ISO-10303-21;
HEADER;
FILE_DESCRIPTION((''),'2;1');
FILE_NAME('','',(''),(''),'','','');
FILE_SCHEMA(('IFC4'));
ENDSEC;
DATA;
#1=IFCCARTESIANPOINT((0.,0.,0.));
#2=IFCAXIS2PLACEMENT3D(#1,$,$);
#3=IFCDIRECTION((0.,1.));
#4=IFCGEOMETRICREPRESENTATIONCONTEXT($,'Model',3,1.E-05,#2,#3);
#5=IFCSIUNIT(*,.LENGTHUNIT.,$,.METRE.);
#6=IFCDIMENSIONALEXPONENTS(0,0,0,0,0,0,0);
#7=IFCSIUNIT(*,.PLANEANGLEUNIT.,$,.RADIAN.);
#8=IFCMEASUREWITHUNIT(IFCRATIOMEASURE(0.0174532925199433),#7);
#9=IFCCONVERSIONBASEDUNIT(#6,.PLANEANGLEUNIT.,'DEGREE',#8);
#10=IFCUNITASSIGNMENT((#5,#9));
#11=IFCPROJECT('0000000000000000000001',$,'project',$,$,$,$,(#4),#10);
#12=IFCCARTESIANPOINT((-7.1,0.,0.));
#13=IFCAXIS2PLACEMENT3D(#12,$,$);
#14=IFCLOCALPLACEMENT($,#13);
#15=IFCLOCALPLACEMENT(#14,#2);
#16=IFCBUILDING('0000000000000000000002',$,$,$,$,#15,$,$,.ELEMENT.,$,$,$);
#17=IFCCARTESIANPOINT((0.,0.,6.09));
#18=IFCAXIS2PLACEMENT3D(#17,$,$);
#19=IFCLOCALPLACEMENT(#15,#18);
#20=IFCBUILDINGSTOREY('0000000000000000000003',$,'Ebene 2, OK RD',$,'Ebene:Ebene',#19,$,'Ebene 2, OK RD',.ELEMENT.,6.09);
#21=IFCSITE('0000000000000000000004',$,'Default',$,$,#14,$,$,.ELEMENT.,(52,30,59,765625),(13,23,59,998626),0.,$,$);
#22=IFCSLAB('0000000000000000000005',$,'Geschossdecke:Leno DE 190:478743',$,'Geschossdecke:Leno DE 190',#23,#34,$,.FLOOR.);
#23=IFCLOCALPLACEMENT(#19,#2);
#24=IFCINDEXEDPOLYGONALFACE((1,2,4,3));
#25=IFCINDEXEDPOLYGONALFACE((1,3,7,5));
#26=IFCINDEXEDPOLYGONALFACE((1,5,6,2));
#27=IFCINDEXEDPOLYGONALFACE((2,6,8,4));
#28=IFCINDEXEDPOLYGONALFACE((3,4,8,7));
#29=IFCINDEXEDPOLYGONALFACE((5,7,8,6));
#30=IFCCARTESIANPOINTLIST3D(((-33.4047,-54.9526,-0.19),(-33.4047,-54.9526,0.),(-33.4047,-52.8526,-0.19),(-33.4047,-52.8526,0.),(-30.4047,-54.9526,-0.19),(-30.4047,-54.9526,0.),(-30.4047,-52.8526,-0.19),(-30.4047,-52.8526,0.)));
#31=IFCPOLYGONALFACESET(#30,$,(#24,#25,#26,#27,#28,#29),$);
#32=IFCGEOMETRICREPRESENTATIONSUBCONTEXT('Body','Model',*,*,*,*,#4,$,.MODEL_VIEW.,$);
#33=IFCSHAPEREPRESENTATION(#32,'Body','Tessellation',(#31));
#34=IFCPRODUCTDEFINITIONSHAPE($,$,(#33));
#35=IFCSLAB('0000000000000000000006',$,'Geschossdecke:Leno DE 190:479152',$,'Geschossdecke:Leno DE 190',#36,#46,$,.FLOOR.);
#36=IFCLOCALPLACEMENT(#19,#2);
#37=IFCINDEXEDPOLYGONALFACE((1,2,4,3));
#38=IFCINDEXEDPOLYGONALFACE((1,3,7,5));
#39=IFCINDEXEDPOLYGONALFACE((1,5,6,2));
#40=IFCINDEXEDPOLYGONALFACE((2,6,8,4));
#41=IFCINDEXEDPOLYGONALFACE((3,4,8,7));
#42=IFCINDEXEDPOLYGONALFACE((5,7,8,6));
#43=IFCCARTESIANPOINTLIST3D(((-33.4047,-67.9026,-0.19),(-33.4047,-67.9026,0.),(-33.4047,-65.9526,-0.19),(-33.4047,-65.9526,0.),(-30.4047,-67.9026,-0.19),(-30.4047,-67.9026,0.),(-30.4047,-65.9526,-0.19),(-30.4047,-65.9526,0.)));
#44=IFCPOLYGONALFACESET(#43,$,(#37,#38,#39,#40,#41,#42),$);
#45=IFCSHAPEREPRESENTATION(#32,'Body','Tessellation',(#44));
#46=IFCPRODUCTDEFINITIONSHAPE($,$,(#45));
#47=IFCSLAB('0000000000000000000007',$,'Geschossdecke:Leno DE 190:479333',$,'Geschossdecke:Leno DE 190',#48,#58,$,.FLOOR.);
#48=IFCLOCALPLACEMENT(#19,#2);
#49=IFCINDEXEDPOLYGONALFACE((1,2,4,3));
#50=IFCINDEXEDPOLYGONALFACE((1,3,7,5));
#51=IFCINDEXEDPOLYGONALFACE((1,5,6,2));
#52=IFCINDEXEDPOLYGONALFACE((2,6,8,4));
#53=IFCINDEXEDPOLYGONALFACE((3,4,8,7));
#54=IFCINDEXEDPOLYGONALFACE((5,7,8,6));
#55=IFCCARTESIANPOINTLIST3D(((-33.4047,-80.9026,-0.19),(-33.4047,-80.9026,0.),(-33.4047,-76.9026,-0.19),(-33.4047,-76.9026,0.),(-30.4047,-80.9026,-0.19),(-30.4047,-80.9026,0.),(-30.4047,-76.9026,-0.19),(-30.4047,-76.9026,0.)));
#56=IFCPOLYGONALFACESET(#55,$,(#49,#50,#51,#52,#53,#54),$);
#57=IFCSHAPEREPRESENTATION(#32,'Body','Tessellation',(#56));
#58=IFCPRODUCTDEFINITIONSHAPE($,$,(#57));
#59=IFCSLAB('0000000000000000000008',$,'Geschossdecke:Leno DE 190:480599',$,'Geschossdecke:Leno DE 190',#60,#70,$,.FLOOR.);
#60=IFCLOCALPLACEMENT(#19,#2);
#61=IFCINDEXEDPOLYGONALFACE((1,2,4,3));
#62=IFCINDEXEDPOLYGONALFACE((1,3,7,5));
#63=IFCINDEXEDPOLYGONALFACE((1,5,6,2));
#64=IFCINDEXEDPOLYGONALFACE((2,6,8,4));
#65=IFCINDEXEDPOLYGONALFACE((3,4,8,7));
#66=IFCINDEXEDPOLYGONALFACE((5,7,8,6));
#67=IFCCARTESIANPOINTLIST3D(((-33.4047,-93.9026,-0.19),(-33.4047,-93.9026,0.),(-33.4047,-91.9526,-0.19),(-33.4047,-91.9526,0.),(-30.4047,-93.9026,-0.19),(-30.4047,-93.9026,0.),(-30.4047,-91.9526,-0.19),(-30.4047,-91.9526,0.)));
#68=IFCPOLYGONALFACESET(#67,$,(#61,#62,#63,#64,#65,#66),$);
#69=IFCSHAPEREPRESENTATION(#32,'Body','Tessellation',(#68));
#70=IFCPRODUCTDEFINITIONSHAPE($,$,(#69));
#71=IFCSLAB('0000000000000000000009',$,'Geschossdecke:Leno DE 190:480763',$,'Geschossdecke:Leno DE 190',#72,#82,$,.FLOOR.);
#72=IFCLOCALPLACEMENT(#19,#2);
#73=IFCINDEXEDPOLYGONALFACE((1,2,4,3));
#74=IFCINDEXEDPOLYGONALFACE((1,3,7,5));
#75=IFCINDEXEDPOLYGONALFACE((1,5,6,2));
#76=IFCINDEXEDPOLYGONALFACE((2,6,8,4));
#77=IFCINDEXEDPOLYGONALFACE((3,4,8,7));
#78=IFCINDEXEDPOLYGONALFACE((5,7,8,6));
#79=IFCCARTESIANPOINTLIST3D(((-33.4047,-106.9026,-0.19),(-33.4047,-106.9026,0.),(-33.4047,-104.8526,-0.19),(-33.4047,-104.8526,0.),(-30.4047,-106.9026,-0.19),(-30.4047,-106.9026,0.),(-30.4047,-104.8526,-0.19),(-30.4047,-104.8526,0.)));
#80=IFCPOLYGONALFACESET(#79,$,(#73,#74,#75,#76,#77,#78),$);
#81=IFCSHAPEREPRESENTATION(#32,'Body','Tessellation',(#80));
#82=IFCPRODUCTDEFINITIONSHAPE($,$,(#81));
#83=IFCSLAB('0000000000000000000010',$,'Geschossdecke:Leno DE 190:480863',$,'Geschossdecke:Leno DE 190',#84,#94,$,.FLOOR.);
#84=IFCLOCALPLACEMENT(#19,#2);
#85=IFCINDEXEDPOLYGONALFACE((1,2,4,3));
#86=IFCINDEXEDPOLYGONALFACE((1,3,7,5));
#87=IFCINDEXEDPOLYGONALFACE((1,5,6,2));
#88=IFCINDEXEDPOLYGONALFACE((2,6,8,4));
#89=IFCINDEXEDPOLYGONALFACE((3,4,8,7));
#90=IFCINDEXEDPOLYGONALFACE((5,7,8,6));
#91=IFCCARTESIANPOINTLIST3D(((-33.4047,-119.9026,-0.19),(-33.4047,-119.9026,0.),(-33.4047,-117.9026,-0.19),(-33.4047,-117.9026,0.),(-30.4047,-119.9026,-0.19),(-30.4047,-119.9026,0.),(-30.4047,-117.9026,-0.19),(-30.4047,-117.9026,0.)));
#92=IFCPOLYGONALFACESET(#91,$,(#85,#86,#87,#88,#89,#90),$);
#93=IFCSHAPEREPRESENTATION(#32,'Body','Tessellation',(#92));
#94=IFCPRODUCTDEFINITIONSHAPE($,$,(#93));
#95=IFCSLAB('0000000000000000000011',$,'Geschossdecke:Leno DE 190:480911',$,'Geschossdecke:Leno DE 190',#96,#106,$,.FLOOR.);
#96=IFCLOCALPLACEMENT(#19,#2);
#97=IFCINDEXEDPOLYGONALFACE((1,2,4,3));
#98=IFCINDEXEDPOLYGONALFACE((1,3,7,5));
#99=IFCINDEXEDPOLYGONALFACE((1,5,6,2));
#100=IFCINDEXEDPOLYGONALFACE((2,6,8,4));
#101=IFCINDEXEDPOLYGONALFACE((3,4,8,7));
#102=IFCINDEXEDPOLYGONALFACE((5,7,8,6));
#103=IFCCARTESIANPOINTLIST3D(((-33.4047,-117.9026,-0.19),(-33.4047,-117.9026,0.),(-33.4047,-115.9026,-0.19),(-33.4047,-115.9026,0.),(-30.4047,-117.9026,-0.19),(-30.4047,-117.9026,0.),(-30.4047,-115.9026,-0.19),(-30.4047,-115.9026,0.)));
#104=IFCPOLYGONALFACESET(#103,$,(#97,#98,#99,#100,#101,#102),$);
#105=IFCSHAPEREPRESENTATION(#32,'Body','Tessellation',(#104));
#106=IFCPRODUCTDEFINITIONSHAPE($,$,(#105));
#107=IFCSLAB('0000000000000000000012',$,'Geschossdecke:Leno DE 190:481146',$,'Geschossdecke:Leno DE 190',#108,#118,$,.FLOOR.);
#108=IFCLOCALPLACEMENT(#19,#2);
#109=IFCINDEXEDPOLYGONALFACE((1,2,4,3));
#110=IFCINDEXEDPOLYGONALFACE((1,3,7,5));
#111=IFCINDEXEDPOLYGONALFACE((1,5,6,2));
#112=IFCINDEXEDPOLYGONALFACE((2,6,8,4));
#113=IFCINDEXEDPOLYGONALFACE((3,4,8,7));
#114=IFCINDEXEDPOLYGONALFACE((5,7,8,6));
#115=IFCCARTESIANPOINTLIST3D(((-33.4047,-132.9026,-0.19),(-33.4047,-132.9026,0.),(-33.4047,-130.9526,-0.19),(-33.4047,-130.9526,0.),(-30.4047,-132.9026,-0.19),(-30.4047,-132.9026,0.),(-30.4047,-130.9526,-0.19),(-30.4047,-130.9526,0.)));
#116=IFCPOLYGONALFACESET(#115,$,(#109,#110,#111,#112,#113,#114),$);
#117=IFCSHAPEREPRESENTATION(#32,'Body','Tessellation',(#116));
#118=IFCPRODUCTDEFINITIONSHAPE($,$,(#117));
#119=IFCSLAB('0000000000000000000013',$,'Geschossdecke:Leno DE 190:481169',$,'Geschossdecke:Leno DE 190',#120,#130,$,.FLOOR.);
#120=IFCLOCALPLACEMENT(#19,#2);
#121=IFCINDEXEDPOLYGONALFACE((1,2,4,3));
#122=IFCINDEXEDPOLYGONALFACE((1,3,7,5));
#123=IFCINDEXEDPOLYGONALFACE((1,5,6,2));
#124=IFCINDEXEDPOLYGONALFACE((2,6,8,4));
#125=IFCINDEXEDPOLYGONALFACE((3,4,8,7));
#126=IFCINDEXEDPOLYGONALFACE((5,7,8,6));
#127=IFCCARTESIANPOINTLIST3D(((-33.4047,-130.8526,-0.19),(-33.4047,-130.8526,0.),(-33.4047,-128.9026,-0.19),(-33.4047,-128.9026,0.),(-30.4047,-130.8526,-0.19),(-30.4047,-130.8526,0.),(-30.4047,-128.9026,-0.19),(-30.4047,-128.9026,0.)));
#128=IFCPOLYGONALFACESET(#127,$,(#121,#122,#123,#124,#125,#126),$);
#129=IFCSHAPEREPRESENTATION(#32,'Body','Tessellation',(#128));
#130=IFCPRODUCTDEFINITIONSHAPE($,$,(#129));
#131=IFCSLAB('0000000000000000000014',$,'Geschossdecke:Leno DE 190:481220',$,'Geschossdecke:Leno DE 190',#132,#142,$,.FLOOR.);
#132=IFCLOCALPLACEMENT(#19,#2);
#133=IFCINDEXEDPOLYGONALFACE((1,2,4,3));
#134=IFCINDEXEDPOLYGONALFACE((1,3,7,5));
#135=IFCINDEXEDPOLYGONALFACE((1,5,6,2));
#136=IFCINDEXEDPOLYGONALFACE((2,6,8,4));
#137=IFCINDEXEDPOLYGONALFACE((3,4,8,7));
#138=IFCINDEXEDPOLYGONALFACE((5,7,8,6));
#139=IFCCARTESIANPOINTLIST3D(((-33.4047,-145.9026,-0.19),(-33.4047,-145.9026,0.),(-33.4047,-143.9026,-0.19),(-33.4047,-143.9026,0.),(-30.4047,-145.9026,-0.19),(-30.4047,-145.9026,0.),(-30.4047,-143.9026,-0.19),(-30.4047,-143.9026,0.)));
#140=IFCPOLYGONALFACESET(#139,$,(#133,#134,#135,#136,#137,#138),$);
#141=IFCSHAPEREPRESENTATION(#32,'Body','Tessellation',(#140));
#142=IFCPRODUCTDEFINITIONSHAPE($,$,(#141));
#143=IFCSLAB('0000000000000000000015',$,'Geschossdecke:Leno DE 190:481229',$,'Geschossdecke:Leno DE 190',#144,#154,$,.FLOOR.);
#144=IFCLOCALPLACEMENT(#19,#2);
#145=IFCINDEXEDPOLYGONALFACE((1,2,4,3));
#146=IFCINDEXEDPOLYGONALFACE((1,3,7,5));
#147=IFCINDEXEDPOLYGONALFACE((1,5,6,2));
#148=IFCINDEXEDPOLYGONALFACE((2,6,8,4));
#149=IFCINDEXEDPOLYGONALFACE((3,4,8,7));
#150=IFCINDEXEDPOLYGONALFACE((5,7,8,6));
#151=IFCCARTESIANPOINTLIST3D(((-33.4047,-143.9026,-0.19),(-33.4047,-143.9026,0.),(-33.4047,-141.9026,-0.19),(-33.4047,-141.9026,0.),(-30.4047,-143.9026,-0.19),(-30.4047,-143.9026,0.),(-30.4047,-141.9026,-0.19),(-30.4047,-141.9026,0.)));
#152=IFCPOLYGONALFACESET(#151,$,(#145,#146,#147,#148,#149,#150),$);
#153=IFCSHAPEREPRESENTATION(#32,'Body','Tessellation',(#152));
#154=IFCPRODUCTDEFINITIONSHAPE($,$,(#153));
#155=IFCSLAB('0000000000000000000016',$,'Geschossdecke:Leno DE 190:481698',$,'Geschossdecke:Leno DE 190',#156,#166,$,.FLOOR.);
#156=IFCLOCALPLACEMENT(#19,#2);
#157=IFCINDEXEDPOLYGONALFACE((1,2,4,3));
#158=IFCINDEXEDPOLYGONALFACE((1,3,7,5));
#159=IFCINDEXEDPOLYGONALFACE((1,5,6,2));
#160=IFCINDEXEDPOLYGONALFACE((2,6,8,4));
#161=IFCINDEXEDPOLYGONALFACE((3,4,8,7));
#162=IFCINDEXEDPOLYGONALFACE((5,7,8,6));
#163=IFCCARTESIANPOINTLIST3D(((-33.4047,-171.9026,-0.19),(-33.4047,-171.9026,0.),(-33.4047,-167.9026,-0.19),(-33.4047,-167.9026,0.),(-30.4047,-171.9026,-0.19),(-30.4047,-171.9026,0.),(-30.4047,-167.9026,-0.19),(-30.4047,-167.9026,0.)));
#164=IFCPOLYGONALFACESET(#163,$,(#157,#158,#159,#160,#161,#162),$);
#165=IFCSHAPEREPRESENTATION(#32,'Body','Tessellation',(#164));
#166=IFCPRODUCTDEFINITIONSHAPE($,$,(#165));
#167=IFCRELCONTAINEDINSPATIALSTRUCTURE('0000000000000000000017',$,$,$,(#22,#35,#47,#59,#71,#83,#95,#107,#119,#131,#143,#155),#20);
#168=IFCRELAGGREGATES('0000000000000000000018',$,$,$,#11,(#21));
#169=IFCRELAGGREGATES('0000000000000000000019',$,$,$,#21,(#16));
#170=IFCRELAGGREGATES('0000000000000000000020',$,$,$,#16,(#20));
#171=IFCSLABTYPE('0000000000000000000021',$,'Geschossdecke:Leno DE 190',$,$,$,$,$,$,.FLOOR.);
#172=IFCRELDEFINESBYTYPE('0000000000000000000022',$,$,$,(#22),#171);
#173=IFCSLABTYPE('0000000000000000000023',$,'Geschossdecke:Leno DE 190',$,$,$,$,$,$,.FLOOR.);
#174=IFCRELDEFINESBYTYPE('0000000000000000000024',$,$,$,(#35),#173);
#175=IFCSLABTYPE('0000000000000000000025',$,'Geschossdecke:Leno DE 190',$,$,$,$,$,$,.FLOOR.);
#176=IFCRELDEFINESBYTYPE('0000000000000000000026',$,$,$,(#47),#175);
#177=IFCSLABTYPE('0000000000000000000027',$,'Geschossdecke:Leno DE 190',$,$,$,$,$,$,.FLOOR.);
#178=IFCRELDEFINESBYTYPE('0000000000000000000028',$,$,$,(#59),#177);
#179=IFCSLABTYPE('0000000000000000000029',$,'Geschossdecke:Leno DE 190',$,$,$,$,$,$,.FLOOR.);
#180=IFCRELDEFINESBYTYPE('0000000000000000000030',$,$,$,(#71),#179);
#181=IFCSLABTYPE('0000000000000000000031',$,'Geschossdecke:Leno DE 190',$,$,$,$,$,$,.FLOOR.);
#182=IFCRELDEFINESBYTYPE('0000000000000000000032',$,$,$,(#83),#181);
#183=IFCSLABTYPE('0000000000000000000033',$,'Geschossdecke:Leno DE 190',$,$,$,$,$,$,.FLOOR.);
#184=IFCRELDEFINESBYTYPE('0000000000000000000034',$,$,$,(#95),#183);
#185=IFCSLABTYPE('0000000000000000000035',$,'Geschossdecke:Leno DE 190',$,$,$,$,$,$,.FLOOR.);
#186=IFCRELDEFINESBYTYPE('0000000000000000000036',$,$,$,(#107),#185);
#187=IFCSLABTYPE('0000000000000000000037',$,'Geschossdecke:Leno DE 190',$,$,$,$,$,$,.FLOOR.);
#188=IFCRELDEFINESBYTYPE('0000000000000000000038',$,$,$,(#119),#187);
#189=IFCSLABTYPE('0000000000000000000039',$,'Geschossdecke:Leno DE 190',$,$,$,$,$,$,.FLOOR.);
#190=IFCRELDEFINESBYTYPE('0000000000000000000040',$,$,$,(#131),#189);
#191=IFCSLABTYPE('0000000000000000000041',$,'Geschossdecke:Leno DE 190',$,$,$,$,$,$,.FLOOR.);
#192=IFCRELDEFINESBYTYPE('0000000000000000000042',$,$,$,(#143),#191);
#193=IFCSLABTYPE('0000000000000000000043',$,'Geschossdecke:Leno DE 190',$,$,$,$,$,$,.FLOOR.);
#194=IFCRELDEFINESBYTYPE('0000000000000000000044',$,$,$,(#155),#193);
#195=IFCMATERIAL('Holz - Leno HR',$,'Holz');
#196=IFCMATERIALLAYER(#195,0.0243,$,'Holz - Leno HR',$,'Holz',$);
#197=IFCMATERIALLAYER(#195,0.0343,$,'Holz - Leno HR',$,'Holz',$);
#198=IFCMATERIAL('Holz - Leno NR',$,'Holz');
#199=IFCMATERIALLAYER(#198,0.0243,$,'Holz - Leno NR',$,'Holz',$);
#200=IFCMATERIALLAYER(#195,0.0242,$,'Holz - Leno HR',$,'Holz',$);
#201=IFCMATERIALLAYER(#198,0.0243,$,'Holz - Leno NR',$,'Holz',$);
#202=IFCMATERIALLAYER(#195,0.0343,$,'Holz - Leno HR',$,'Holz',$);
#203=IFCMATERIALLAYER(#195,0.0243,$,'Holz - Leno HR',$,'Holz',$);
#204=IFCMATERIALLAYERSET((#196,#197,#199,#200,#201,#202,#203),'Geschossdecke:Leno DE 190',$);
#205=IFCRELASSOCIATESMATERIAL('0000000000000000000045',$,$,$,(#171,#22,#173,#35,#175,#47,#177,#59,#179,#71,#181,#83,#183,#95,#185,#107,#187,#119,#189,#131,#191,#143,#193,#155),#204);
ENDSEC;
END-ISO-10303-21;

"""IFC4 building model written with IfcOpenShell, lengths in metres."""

from ifc_helpers import new_model, entity, si_unit, converted_unit, direction, frame, origin, place, context, subcontext, project, spatial, indexed_curve, outline, extrude, material, layer, layer_set, type_object, element, save


model = new_model("IFC4")

# Units and contexts
model_context = context("Model", 3, precision=1e-05, world=origin(), true_north=direction((0.0, 1.0)))
body_context = subcontext(model_context, "Body", "Model", "MODEL_VIEW")
ifc_project = project(units=[si_unit("LENGTHUNIT", "METRE"), converted_unit("PLANEANGLEUNIT", "DEGREE", entity("IfcRatioMeasure", 0.0174532925199433), si_unit("PLANEANGLEUNIT", "RADIAN"), dimensions=[0, 0, 0, 0, 0, 0, 0])], contexts=[model_context])

# Site, building, storey
site_placement = place(None, frame((-7.1, 0.0, 0.0)))
site = spatial("IfcSite", under=ifc_project, at=site_placement, Name="Default", CompositionType="ELEMENT", RefLatitude=(52, 30, 59, 765625), RefLongitude=(13, 23, 59, 998626), RefElevation=0.0)
building_placement = place(site_placement, origin())
building = spatial("IfcBuilding", under=site, at=building_placement, CompositionType="ELEMENT")
storey_placement = place(building_placement, frame((0.0, 0.0, 6.09)))
storey = spatial("IfcBuildingStorey", under=building, at=storey_placement, Name="Ebene 2, OK RD", ObjectType="Ebene:Ebene", LongName="Ebene 2, OK RD", CompositionType="ELEMENT", Elevation=6.09)

# Slabs
ifc_material_1 = material(Name="Holz - Leno HR", Category="Holz")
ifc_layer_1 = layer(ifc_material_1, 0.0243, Name="Holz - Leno HR", Category="Holz")
ifc_layer_2 = layer(ifc_material_1, 0.0343, Name="Holz - Leno HR", Category="Holz")
ifc_material_2 = material(Name="Holz - Leno NR", Category="Holz")
ifc_layer_3 = layer(ifc_material_2, 0.0243, Name="Holz - Leno NR", Category="Holz")
ifc_layer_4 = layer(ifc_material_1, 0.0242, Name="Holz - Leno HR", Category="Holz")
ifc_layer_5 = layer(ifc_material_2, 0.0243, Name="Holz - Leno NR", Category="Holz")
ifc_layer_6 = layer(ifc_material_1, 0.0343, Name="Holz - Leno HR", Category="Holz")
ifc_layer_7 = layer(ifc_material_1, 0.0243, Name="Holz - Leno HR", Category="Holz")
ifc_layer_set_1 = layer_set([ifc_layer_1, ifc_layer_2, ifc_layer_3, ifc_layer_4, ifc_layer_5, ifc_layer_6, ifc_layer_7], Name="Geschossdecke:Leno DE 190")
slab_type_1 = type_object("IfcSlabType", Name="Geschossdecke:Leno DE 190", PredefinedType="FLOOR", material=ifc_layer_set_1)
slab_1_placement = place(storey_placement, origin())
element("IfcSlab", 1, at=slab_1_placement, inside=storey, type_object=slab_type_1, material=ifc_layer_set_1, Name="Geschossdecke:Leno DE 190:478743", ObjectType="Geschossdecke:Leno DE 190", PredefinedType="FLOOR", context=body_context, shape_type="SweptSolid", body=[
    extrude(outline(indexed_curve([(-1.05, -1.5), (1.05, -1.5), (1.05, 1.5), (-1.05, 1.5), (-1.05, -1.5)], self_intersect=False)), frame((-31.9047, -53.9026, 0.0), z_axis=(0.0, 0.0, -1.0), x_axis=(0.0, 1.0, 0.0)), (0.0, 0.0, 1.0), 0.19),
])
slab_type_2 = type_object("IfcSlabType", Name="Geschossdecke:Leno DE 190", PredefinedType="FLOOR", material=ifc_layer_set_1)
slab_2_placement = place(storey_placement, origin())
element("IfcSlab", 2, at=slab_2_placement, inside=storey, type_object=slab_type_2, material=ifc_layer_set_1, Name="Geschossdecke:Leno DE 190:479152", ObjectType="Geschossdecke:Leno DE 190", PredefinedType="FLOOR", context=body_context, shape_type="SweptSolid", body=[
    extrude(outline(indexed_curve([(-0.975, -1.5), (0.975, -1.5), (0.975, 1.5), (-0.975, 1.5), (-0.975, -1.5)], self_intersect=False)), frame((-31.9047, -66.9276, 0.0), z_axis=(0.0, 0.0, -1.0), x_axis=(0.0, 1.0, 0.0)), (0.0, 0.0, 1.0), 0.19),
])
slab_type_3 = type_object("IfcSlabType", Name="Geschossdecke:Leno DE 190", PredefinedType="FLOOR", material=ifc_layer_set_1)
slab_3_placement = place(storey_placement, origin())
element("IfcSlab", 3, at=slab_3_placement, inside=storey, type_object=slab_type_3, material=ifc_layer_set_1, Name="Geschossdecke:Leno DE 190:479333", ObjectType="Geschossdecke:Leno DE 190", PredefinedType="FLOOR", context=body_context, shape_type="SweptSolid", body=[
    extrude(outline(indexed_curve([(-2.0, -1.5), (2.0, -1.5), (2.0, 1.5), (-2.0, 1.5), (-2.0, -1.5)], self_intersect=False)), frame((-31.9047, -78.9026, 0.0), z_axis=(0.0, 0.0, -1.0), x_axis=(0.0, 1.0, 0.0)), (0.0, 0.0, 1.0), 0.19),
])
slab_type_4 = type_object("IfcSlabType", Name="Geschossdecke:Leno DE 190", PredefinedType="FLOOR", material=ifc_layer_set_1)
slab_4_placement = place(storey_placement, origin())
element("IfcSlab", 4, at=slab_4_placement, inside=storey, type_object=slab_type_4, material=ifc_layer_set_1, Name="Geschossdecke:Leno DE 190:480599", ObjectType="Geschossdecke:Leno DE 190", PredefinedType="FLOOR", context=body_context, shape_type="SweptSolid", body=[
    extrude(outline(indexed_curve([(-0.975, -1.5), (0.975, -1.5), (0.975, 1.5), (-0.975, 1.5), (-0.975, -1.5)], self_intersect=False)), frame((-31.9047, -92.9276, 0.0), z_axis=(0.0, 0.0, -1.0), x_axis=(0.0, 1.0, 0.0)), (0.0, 0.0, 1.0), 0.19),
])
slab_type_5 = type_object("IfcSlabType", Name="Geschossdecke:Leno DE 190", PredefinedType="FLOOR", material=ifc_layer_set_1)
slab_5_placement = place(storey_placement, origin())
element("IfcSlab", 5, at=slab_5_placement, inside=storey, type_object=slab_type_5, material=ifc_layer_set_1, Name="Geschossdecke:Leno DE 190:480763", ObjectType="Geschossdecke:Leno DE 190", PredefinedType="FLOOR", context=body_context, shape_type="SweptSolid", body=[
    extrude(outline(indexed_curve([(-1.025, -1.5), (1.025, -1.5), (1.025, 1.5), (-1.025, 1.5), (-1.025, -1.5)], self_intersect=False)), frame((-31.9047, -105.8776, 0.0), z_axis=(0.0, 0.0, -1.0), x_axis=(0.0, 1.0, 0.0)), (0.0, 0.0, 1.0), 0.19),
])
slab_type_6 = type_object("IfcSlabType", Name="Geschossdecke:Leno DE 190", PredefinedType="FLOOR", material=ifc_layer_set_1)
slab_6_placement = place(storey_placement, origin())
element("IfcSlab", 6, at=slab_6_placement, inside=storey, type_object=slab_type_6, material=ifc_layer_set_1, Name="Geschossdecke:Leno DE 190:480863", ObjectType="Geschossdecke:Leno DE 190", PredefinedType="FLOOR", context=body_context, shape_type="SweptSolid", body=[
    extrude(outline(indexed_curve([(-1.0, -1.5), (1.0, -1.5), (1.0, 1.5), (-1.0, 1.5), (-1.0, -1.5)], self_intersect=False)), frame((-31.9047, -118.9026, 0.0), z_axis=(0.0, 0.0, -1.0), x_axis=(0.0, 1.0, 0.0)), (0.0, 0.0, 1.0), 0.19),
])
slab_type_7 = type_object("IfcSlabType", Name="Geschossdecke:Leno DE 190", PredefinedType="FLOOR", material=ifc_layer_set_1)
slab_7_placement = place(storey_placement, origin())
element("IfcSlab", 7, at=slab_7_placement, inside=storey, type_object=slab_type_7, material=ifc_layer_set_1, Name="Geschossdecke:Leno DE 190:480911", ObjectType="Geschossdecke:Leno DE 190", PredefinedType="FLOOR", context=body_context, shape_type="SweptSolid", body=[
    extrude(outline(indexed_curve([(-1.0, -1.5), (1.0, -1.5), (1.0, 1.5), (-1.0, 1.5), (-1.0, -1.5)], self_intersect=False)), frame((-31.9047, -116.9026, 0.0), z_axis=(0.0, 0.0, -1.0), x_axis=(0.0, 1.0, 0.0)), (0.0, 0.0, 1.0), 0.19),
])
slab_type_8 = type_object("IfcSlabType", Name="Geschossdecke:Leno DE 190", PredefinedType="FLOOR", material=ifc_layer_set_1)
slab_8_placement = place(storey_placement, origin())
element("IfcSlab", 8, at=slab_8_placement, inside=storey, type_object=slab_type_8, material=ifc_layer_set_1, Name="Geschossdecke:Leno DE 190:481146", ObjectType="Geschossdecke:Leno DE 190", PredefinedType="FLOOR", context=body_context, shape_type="SweptSolid", body=[
    extrude(outline(indexed_curve([(-0.975, -1.5), (0.975, -1.5), (0.975, 1.5), (-0.975, 1.5), (-0.975, -1.5)], self_intersect=False)), frame((-31.9047, -131.9276, 0.0), z_axis=(0.0, 0.0, -1.0), x_axis=(0.0, 1.0, 0.0)), (0.0, 0.0, 1.0), 0.19),
])
slab_type_9 = type_object("IfcSlabType", Name="Geschossdecke:Leno DE 190", PredefinedType="FLOOR", material=ifc_layer_set_1)
slab_9_placement = place(storey_placement, origin())
element("IfcSlab", 9, at=slab_9_placement, inside=storey, type_object=slab_type_9, material=ifc_layer_set_1, Name="Geschossdecke:Leno DE 190:481169", ObjectType="Geschossdecke:Leno DE 190", PredefinedType="FLOOR", context=body_context, shape_type="SweptSolid", body=[
    extrude(outline(indexed_curve([(-0.975, -1.5), (0.975, -1.5), (0.975, 1.5), (-0.975, 1.5), (-0.975, -1.5)], self_intersect=False)), frame((-31.9047, -129.8776, 0.0), z_axis=(0.0, 0.0, -1.0), x_axis=(0.0, 1.0, 0.0)), (0.0, 0.0, 1.0), 0.19),
])
slab_type_10 = type_object("IfcSlabType", Name="Geschossdecke:Leno DE 190", PredefinedType="FLOOR", material=ifc_layer_set_1)
slab_10_placement = place(storey_placement, origin())
element("IfcSlab", 10, at=slab_10_placement, inside=storey, type_object=slab_type_10, material=ifc_layer_set_1, Name="Geschossdecke:Leno DE 190:481220", ObjectType="Geschossdecke:Leno DE 190", PredefinedType="FLOOR", context=body_context, shape_type="SweptSolid", body=[
    extrude(outline(indexed_curve([(-1.0, -1.5), (1.0, -1.5), (1.0, 1.5), (-1.0, 1.5), (-1.0, -1.5)], self_intersect=False)), frame((-31.9047, -144.9026, 0.0), z_axis=(0.0, 0.0, -1.0), x_axis=(0.0, 1.0, 0.0)), (0.0, 0.0, 1.0), 0.19),
])
slab_type_11 = type_object("IfcSlabType", Name="Geschossdecke:Leno DE 190", PredefinedType="FLOOR", material=ifc_layer_set_1)
slab_11_placement = place(storey_placement, origin())
element("IfcSlab", 11, at=slab_11_placement, inside=storey, type_object=slab_type_11, material=ifc_layer_set_1, Name="Geschossdecke:Leno DE 190:481229", ObjectType="Geschossdecke:Leno DE 190", PredefinedType="FLOOR", context=body_context, shape_type="SweptSolid", body=[
    extrude(outline(indexed_curve([(-1.0, -1.5), (1.0, -1.5), (1.0, 1.5), (-1.0, 1.5), (-1.0, -1.5)], self_intersect=False)), frame((-31.9047, -142.9026, 0.0), z_axis=(0.0, 0.0, -1.0), x_axis=(0.0, 1.0, 0.0)), (0.0, 0.0, 1.0), 0.19),
])
slab_type_12 = type_object("IfcSlabType", Name="Geschossdecke:Leno DE 190", PredefinedType="FLOOR", material=ifc_layer_set_1)
slab_12_placement = place(storey_placement, origin())
element("IfcSlab", 12, at=slab_12_placement, inside=storey, type_object=slab_type_12, material=ifc_layer_set_1, Name="Geschossdecke:Leno DE 190:481698", ObjectType="Geschossdecke:Leno DE 190", PredefinedType="FLOOR", context=body_context, shape_type="SweptSolid", body=[
    extrude(outline(indexed_curve([(-2.0, -1.5), (2.0, -1.5), (2.0, 1.5), (-2.0, 1.5), (-2.0, -1.5)], self_intersect=False)), frame((-31.9047, -169.9026, 0.0), z_axis=(0.0, 0.0, -1.0), x_axis=(0.0, 1.0, 0.0)), (0.0, 0.0, 1.0), 0.19),
])

save(model, "model.ifc")
